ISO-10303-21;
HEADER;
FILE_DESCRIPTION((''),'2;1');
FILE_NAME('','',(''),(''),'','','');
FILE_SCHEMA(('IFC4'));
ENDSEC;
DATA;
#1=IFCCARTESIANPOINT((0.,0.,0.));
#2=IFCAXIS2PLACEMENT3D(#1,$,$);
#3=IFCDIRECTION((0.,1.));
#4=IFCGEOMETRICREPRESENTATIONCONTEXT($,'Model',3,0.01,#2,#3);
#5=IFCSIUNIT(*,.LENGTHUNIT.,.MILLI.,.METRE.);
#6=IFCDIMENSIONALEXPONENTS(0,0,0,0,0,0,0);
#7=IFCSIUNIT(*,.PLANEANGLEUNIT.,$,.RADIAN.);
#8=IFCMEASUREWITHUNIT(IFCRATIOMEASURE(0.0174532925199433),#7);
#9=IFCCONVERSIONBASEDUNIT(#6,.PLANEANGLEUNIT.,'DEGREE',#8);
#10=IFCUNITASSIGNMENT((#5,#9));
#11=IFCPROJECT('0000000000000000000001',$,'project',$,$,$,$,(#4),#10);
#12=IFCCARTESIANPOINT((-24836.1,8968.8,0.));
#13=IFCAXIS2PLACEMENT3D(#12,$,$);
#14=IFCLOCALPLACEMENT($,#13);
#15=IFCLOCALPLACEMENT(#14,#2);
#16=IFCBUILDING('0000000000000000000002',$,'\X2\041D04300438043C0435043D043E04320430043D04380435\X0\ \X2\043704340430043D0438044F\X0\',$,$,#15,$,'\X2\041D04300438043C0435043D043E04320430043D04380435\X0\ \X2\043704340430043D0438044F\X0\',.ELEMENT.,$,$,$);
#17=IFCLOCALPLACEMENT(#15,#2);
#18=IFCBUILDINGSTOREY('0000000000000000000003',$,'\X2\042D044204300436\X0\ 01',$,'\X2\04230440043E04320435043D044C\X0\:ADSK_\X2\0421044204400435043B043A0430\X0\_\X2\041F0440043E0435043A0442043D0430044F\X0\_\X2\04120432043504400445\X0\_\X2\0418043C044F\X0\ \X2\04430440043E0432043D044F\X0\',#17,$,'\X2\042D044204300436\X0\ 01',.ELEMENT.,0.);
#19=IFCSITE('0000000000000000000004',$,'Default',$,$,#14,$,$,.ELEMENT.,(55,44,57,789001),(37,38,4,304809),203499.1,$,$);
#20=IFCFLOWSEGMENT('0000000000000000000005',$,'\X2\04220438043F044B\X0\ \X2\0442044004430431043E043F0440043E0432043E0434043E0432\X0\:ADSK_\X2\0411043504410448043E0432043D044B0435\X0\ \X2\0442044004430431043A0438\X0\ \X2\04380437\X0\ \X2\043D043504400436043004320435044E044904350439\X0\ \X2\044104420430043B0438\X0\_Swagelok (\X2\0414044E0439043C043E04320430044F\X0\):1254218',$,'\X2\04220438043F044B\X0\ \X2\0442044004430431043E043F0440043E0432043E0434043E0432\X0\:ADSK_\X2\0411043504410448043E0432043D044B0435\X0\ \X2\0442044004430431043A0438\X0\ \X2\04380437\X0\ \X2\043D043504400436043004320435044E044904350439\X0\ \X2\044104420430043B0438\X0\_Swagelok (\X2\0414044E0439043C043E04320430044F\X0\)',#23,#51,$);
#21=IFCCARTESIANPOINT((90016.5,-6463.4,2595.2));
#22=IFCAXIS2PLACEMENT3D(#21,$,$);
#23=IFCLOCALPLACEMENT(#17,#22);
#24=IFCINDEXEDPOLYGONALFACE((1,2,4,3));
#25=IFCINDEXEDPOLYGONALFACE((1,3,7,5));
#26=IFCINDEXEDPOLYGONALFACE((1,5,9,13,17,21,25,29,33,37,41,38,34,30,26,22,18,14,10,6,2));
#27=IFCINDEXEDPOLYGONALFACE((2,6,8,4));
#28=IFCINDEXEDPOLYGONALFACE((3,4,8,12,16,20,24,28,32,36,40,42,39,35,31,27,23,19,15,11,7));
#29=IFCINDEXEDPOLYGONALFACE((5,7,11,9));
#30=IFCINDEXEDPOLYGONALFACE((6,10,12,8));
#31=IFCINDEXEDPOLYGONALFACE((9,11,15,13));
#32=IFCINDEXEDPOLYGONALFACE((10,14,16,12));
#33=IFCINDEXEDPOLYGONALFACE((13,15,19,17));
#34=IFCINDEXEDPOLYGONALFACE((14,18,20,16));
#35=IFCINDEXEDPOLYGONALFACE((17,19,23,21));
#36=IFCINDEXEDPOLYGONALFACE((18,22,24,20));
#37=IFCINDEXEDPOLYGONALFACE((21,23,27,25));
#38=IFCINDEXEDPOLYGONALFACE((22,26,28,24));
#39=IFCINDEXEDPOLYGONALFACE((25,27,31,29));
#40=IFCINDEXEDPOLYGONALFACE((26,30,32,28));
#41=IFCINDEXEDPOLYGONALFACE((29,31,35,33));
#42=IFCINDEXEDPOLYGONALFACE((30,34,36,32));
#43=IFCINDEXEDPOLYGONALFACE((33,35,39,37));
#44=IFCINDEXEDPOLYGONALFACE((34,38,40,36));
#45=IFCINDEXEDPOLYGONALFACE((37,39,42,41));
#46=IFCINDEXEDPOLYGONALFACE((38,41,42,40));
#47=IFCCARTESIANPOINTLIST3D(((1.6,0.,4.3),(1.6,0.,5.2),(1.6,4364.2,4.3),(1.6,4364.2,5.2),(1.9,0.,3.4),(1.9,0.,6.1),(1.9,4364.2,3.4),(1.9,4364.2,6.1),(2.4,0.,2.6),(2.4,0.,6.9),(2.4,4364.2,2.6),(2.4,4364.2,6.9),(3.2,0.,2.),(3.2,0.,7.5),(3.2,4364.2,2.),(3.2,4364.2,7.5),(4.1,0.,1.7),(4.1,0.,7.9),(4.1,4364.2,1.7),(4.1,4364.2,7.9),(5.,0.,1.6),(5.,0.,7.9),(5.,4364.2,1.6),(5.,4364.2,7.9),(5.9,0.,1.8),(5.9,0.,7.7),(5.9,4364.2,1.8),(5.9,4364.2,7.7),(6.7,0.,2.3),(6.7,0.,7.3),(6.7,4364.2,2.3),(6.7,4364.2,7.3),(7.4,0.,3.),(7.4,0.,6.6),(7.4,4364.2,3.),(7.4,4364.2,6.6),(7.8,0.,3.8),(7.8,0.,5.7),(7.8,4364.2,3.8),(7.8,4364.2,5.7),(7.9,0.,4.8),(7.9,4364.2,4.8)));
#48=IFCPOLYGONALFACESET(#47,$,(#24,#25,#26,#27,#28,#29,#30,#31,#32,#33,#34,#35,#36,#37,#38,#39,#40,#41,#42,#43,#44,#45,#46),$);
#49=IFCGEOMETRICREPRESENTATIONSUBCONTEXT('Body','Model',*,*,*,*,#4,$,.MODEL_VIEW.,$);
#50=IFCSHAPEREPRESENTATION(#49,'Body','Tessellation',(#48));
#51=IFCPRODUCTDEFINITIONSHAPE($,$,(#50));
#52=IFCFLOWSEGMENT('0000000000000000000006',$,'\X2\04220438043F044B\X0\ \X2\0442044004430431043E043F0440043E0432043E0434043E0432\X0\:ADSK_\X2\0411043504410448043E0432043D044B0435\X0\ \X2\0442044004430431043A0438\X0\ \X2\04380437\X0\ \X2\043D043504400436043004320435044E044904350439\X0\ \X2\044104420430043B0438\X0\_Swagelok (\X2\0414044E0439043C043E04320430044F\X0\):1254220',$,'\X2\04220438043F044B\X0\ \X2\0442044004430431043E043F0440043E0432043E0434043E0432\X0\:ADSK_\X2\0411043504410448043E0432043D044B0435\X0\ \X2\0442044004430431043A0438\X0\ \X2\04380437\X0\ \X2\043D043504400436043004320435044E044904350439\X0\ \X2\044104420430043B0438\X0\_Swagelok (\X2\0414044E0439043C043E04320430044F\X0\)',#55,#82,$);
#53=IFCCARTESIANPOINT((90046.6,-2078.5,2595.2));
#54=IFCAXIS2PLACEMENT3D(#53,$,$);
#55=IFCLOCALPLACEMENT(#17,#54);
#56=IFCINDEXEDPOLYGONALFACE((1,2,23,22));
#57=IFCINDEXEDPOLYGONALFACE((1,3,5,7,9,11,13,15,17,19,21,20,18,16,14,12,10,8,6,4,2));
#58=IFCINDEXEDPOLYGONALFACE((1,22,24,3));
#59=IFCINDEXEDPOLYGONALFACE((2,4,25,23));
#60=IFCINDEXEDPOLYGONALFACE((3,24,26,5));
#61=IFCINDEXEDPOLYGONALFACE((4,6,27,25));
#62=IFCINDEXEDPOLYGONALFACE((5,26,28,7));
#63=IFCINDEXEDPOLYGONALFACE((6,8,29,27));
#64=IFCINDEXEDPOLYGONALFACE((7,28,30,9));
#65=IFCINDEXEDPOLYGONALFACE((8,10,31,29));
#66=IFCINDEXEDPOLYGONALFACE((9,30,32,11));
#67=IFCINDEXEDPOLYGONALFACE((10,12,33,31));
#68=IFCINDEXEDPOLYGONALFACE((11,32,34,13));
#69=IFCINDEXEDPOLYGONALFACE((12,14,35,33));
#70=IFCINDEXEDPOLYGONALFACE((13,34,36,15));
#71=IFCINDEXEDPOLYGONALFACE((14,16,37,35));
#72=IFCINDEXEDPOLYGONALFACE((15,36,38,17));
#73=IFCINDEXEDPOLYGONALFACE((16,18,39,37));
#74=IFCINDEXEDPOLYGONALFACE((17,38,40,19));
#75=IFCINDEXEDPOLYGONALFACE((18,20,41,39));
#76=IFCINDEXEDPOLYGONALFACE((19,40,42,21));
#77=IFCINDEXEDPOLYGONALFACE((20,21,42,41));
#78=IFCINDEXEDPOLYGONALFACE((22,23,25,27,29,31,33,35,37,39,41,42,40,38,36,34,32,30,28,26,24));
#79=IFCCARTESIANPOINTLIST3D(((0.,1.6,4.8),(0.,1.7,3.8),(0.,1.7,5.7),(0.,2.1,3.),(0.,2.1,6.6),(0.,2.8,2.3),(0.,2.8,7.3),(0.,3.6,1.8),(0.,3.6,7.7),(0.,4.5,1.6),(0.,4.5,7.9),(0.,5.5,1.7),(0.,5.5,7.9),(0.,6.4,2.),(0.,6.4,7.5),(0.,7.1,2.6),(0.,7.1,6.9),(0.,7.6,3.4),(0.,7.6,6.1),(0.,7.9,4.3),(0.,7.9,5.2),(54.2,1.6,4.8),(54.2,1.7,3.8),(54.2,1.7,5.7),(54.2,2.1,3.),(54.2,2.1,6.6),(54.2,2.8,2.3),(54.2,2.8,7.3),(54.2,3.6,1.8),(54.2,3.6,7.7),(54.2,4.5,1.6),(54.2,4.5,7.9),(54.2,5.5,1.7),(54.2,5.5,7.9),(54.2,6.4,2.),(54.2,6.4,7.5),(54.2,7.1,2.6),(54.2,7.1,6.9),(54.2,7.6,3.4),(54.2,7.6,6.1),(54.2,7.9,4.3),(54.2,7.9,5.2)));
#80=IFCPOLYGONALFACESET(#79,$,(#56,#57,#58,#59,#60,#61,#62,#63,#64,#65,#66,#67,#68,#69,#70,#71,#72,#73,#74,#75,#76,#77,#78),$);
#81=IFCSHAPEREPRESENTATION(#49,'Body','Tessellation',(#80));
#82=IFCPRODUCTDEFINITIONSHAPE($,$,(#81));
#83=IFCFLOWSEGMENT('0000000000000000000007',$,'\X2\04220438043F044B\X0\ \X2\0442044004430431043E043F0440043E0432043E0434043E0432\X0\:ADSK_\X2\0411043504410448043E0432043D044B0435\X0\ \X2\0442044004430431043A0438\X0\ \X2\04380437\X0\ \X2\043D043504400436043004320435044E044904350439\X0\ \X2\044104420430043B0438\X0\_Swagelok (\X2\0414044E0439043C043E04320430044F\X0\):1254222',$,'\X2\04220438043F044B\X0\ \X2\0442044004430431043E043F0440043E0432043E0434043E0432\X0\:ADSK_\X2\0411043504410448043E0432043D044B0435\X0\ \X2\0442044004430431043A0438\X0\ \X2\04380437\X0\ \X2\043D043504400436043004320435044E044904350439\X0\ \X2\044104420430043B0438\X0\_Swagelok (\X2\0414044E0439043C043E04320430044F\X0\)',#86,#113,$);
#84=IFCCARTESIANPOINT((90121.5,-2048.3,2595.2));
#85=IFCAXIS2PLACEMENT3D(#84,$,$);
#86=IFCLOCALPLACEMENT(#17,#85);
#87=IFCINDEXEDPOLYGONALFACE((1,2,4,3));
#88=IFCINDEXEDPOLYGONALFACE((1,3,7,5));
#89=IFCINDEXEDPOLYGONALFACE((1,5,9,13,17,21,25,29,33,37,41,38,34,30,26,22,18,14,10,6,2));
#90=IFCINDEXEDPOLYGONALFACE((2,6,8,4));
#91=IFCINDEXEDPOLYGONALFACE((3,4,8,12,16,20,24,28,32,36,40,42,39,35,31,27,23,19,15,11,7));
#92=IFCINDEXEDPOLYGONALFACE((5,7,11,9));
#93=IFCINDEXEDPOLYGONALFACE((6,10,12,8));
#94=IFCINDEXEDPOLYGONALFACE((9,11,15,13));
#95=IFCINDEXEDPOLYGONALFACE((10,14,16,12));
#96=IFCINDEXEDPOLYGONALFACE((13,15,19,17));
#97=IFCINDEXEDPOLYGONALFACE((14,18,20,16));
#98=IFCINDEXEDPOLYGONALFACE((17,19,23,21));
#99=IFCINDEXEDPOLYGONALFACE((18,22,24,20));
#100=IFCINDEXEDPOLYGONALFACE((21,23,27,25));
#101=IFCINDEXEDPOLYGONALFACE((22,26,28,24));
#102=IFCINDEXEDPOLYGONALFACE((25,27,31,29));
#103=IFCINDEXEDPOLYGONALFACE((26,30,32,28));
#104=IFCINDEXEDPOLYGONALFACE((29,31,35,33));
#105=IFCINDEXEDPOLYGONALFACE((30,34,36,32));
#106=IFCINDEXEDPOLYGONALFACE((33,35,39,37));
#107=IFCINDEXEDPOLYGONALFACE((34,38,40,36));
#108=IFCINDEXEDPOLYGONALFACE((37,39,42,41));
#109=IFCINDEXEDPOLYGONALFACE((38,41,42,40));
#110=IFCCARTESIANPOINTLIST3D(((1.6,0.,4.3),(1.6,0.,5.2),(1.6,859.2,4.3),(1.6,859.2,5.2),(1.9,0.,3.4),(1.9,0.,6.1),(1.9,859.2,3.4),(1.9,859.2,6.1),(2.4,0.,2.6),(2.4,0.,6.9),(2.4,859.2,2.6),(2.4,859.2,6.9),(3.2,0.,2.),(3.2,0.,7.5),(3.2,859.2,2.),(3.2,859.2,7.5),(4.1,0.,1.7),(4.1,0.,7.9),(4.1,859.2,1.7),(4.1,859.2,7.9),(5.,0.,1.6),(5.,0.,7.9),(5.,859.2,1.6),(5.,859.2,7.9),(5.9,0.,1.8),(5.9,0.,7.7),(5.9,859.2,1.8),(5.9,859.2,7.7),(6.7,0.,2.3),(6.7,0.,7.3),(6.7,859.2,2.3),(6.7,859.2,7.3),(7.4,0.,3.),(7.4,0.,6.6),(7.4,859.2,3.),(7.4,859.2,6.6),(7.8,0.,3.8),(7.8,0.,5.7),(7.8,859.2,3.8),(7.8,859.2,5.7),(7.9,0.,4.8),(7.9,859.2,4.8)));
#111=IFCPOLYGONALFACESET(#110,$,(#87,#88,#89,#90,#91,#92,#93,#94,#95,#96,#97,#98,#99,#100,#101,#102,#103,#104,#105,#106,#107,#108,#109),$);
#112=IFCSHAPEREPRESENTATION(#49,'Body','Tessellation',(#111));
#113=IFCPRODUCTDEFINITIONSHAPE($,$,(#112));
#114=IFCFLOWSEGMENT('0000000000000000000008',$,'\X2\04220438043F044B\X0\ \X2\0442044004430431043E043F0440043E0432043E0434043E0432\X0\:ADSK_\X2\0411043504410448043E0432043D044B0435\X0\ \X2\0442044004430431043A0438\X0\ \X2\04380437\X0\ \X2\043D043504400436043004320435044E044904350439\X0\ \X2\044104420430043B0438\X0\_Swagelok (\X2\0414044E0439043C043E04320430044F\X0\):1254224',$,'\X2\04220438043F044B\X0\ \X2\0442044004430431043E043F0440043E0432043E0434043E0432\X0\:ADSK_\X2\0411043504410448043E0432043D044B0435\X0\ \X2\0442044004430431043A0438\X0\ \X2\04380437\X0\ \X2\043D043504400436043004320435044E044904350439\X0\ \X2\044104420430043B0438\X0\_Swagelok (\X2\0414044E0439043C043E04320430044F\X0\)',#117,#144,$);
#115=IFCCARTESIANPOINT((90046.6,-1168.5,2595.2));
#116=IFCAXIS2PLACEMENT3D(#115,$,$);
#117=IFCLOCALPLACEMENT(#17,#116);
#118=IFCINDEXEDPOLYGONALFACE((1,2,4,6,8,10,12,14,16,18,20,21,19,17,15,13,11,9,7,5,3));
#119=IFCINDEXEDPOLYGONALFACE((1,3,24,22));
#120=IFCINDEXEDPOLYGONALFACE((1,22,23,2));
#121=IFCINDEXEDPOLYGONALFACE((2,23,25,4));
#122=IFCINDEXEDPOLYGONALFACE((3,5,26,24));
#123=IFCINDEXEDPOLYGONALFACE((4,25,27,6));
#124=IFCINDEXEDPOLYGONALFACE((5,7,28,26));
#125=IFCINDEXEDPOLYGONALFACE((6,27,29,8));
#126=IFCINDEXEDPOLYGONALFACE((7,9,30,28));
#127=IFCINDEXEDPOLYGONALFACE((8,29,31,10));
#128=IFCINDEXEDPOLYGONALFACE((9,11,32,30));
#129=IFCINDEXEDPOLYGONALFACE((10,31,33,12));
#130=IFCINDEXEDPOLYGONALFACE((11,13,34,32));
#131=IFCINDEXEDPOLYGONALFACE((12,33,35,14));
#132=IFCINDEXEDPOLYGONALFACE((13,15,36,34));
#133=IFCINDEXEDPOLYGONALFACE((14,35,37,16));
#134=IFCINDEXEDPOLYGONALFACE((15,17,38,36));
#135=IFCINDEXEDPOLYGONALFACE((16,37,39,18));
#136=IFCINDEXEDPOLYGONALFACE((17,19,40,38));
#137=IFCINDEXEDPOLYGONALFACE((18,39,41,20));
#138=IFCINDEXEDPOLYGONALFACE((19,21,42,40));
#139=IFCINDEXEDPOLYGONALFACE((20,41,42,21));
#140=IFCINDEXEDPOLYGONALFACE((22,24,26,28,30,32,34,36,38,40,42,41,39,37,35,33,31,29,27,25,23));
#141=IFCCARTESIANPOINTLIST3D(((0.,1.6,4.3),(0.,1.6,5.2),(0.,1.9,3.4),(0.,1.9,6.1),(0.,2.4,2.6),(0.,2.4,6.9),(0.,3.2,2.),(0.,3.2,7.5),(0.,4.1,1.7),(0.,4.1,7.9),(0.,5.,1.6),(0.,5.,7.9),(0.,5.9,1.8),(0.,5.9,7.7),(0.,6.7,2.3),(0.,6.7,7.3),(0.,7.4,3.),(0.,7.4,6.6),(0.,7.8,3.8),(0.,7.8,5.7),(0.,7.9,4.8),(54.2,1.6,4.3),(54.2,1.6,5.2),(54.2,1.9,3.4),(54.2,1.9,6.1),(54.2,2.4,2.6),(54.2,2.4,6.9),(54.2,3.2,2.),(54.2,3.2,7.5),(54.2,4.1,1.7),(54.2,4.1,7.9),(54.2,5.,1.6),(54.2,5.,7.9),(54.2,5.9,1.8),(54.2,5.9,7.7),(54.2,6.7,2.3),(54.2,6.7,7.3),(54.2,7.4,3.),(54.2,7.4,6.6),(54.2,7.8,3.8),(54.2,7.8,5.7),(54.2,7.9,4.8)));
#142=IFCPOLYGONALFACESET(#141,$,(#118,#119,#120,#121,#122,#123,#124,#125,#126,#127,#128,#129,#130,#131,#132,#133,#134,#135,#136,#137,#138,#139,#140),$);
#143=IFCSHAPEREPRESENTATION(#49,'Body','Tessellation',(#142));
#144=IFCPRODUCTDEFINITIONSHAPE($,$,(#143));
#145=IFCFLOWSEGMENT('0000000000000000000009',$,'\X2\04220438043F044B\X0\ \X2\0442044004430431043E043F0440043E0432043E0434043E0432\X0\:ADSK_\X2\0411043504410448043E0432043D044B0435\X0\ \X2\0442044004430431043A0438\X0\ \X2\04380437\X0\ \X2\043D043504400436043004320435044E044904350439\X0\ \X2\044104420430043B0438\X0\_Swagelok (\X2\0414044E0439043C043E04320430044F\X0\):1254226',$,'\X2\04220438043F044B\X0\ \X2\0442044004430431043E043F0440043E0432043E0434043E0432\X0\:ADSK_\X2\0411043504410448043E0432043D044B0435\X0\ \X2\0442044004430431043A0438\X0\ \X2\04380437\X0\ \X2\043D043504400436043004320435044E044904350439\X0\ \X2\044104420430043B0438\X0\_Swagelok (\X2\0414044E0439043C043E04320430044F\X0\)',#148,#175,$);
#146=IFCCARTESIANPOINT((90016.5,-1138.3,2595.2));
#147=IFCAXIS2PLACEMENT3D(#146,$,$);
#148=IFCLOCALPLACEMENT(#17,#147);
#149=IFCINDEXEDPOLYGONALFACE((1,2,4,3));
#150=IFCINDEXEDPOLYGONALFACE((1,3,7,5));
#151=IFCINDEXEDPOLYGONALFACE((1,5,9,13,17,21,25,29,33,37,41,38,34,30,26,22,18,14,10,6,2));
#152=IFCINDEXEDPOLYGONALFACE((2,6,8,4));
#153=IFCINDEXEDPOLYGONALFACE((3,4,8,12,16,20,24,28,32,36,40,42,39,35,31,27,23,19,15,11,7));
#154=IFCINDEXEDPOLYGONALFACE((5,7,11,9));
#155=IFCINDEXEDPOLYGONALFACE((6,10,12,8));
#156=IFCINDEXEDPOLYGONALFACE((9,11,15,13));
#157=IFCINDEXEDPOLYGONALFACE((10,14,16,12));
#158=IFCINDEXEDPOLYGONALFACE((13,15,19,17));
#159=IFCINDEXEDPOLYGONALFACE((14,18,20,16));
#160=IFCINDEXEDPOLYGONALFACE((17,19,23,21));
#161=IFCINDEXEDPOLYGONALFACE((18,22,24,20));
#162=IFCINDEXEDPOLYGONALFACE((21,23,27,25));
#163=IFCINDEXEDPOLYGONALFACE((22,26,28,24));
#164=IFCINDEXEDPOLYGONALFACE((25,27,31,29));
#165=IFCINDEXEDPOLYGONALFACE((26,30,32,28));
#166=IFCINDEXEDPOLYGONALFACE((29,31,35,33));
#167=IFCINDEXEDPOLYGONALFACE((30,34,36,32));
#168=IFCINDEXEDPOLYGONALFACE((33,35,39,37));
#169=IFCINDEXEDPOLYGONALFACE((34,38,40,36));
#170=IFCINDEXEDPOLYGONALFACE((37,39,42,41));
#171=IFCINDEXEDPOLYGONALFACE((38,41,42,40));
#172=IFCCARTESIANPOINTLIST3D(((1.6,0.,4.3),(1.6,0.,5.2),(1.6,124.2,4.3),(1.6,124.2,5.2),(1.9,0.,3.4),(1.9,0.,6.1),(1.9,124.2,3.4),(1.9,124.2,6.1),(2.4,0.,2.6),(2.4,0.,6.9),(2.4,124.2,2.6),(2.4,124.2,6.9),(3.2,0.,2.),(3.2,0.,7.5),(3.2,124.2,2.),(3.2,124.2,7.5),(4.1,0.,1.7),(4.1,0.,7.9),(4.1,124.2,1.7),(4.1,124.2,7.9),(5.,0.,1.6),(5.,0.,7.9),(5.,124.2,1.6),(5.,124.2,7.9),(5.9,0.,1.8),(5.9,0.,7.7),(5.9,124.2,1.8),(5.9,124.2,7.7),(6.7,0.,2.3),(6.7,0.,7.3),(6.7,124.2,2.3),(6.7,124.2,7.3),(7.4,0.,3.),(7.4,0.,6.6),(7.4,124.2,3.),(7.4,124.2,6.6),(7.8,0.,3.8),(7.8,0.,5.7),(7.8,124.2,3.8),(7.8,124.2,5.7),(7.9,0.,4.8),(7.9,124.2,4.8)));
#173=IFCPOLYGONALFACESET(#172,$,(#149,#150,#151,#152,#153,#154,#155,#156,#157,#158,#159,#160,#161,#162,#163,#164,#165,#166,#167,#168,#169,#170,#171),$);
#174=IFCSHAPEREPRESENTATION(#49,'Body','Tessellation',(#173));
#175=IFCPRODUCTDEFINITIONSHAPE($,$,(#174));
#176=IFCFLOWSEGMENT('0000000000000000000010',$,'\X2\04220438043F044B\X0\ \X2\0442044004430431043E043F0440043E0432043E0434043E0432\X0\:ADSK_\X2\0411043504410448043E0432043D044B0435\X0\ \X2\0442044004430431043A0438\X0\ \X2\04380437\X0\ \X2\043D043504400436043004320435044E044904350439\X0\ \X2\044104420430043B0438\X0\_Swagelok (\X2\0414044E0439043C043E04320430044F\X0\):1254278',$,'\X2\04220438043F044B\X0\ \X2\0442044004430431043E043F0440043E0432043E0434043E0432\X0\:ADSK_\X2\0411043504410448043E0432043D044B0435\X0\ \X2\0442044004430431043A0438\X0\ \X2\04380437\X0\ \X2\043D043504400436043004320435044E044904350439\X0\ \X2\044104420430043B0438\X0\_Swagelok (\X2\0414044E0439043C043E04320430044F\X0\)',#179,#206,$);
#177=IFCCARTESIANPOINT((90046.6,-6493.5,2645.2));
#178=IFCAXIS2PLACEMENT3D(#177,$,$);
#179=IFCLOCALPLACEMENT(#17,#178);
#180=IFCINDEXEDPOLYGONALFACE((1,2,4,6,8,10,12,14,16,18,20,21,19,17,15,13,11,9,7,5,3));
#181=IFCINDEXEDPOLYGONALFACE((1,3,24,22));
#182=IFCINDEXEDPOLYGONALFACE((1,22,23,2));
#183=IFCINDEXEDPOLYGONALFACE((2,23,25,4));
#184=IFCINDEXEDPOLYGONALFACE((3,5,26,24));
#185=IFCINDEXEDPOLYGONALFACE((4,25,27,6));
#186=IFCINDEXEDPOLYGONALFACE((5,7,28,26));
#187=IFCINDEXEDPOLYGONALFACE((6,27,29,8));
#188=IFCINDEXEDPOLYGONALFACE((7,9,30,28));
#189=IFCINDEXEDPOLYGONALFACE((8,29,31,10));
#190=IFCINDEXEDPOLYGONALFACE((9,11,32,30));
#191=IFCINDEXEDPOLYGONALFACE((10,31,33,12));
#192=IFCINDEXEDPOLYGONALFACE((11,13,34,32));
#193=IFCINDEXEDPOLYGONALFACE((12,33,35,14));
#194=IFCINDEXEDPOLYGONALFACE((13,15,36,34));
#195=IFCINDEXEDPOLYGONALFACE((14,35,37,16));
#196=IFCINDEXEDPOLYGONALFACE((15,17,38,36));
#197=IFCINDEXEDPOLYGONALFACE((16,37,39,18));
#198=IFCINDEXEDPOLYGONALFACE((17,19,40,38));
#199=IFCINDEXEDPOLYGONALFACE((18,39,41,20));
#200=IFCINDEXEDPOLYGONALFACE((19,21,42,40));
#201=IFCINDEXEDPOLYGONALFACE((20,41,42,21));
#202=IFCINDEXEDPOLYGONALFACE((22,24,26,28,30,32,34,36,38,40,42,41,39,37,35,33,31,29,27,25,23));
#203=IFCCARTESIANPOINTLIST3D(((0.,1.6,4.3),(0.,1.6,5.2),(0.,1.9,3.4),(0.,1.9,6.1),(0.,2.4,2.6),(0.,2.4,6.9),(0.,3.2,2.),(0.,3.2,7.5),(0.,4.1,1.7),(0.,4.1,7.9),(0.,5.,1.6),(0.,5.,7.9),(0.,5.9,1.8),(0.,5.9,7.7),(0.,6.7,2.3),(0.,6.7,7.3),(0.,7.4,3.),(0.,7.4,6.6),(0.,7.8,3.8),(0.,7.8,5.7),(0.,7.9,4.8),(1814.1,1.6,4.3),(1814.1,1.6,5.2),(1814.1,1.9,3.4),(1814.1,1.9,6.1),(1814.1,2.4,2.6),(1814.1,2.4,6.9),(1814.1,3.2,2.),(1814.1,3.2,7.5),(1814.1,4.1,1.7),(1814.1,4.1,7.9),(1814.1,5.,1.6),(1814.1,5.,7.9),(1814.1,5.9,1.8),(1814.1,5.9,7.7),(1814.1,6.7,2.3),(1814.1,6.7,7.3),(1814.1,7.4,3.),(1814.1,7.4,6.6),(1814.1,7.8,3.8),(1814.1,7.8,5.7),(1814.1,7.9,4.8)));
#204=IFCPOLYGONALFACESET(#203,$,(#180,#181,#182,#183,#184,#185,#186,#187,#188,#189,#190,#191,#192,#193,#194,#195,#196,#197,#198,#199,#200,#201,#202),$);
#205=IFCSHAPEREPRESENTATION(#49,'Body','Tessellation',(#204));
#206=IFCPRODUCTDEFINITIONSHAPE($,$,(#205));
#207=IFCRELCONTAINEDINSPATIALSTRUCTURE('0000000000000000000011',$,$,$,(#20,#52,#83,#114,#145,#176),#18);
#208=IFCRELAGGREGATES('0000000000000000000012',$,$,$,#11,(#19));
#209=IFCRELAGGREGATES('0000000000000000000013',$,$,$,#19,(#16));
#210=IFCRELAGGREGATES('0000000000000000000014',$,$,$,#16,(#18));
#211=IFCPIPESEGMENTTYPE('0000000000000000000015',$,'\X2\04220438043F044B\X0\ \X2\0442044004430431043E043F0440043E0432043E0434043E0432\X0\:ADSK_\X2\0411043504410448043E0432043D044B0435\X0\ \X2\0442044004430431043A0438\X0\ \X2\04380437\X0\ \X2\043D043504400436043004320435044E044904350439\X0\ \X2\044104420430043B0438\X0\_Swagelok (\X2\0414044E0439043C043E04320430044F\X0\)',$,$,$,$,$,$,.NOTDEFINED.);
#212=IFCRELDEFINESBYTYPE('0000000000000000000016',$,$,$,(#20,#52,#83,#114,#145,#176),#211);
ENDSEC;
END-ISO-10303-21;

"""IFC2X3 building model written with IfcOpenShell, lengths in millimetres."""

from ifc_helpers import new_model, entity, si_unit, converted_unit, direction, frame, origin, origin_2d_with_axis, place, context, subcontext, project, spatial, circle, extrude, type_object, element, save


model = new_model("IFC2X3")

# Units and contexts
model_context = context("Model", 3, precision=0.01, world=origin(), true_north=direction((0.0, 1.0)))
body_context = subcontext(model_context, "Body", "Model", "MODEL_VIEW")
ifc_project = project(units=[si_unit("LENGTHUNIT", "METRE", prefix="MILLI"), converted_unit("PLANEANGLEUNIT", "DEGREE", entity("IfcRatioMeasure", 0.0174532925199433), si_unit("PLANEANGLEUNIT", "RADIAN"), dimensions=[0, 0, 0, 0, 0, 0, 0])], contexts=[model_context])

# Site, building, storey
site_placement = place(None, frame((-24836.1, 8968.8, 0.0)))
site = spatial("IfcSite", under=ifc_project, at=site_placement, Name="Default", CompositionType="ELEMENT", RefLatitude=(55, 44, 57, 789001), RefLongitude=(37, 38, 4, 304809), RefElevation=203499.1)
building_placement = place(site_placement, origin())
building = spatial("IfcBuilding", under=site, at=building_placement, Name="Наименование здания", LongName="Наименование здания", CompositionType="ELEMENT")
storey_placement = place(building_placement, origin())
storey = spatial("IfcBuildingStorey", under=building, at=storey_placement, Name="Этаж 01", ObjectType="Уровень:ADSK_Стрелка_Проектная_Вверх_Имя уровня", LongName="Этаж 01", CompositionType="ELEMENT", Elevation=0.0)

# Flow segments
pipe_segment_type_1 = type_object("IfcPipeSegmentType", Name="Типы трубопроводов:ADSK_Бесшовные трубки из нержавеющей стали_Swagelok (Дюймовая)", PredefinedType="NOTDEFINED")
flow_segment_1_placement = place(storey_placement, frame((90016.5, -6463.4, 2595.2)))
element("IfcFlowSegment", 1, at=flow_segment_1_placement, inside=storey, type_object=pipe_segment_type_1, Name="Типы трубопроводов:ADSK_Бесшовные трубки из нержавеющей стали_Swagelok (Дюймовая):1254218", ObjectType="Типы трубопроводов:ADSK_Бесшовные трубки из нержавеющей стали_Swagelok (Дюймовая)", context=body_context, shape_type="SweptSolid", body=[
    extrude(circle(Radius=3.2, at=origin_2d_with_axis()), frame((4.8, 0.0, 4.8), z_axis=(0.0, 1.0, 0.0), x_axis=(1.0, 0.0, 0.0)), (0.0, 0.0, 1.0), 4364.2),
])
flow_segment_2_placement = place(storey_placement, frame((90046.6, -2078.5, 2595.2)))
element("IfcFlowSegment", 2, at=flow_segment_2_placement, inside=storey, type_object=pipe_segment_type_1, Name="Типы трубопроводов:ADSK_Бесшовные трубки из нержавеющей стали_Swagelok (Дюймовая):1254220", ObjectType="Типы трубопроводов:ADSK_Бесшовные трубки из нержавеющей стали_Swagelok (Дюймовая)", context=body_context, shape_type="SweptSolid", body=[
    extrude(circle(Radius=3.2, at=origin_2d_with_axis()), frame((0.0, 4.8, 4.8), z_axis=(1.0, 0.0, 0.0), x_axis=(0.0, -1.0, 0.0)), (0.0, 0.0, 1.0), 54.2),
])
flow_segment_3_placement = place(storey_placement, frame((90121.5, -2048.3, 2595.2)))
element("IfcFlowSegment", 3, at=flow_segment_3_placement, inside=storey, type_object=pipe_segment_type_1, Name="Типы трубопроводов:ADSK_Бесшовные трубки из нержавеющей стали_Swagelok (Дюймовая):1254222", ObjectType="Типы трубопроводов:ADSK_Бесшовные трубки из нержавеющей стали_Swagelok (Дюймовая)", context=body_context, shape_type="SweptSolid", body=[
    extrude(circle(Radius=3.2, at=origin_2d_with_axis()), frame((4.8, 0.0, 4.8), z_axis=(0.0, 1.0, 0.0), x_axis=(1.0, 0.0, 0.0)), (0.0, 0.0, 1.0), 859.2),
])
flow_segment_4_placement = place(storey_placement, frame((90046.6, -1168.5, 2595.2)))
element("IfcFlowSegment", 4, at=flow_segment_4_placement, inside=storey, type_object=pipe_segment_type_1, Name="Типы трубопроводов:ADSK_Бесшовные трубки из нержавеющей стали_Swagelok (Дюймовая):1254224", ObjectType="Типы трубопроводов:ADSK_Бесшовные трубки из нержавеющей стали_Swagelok (Дюймовая)", context=body_context, shape_type="SweptSolid", body=[
    extrude(circle(Radius=3.2, at=origin_2d_with_axis()), frame((0.0, 4.8, 4.8), z_axis=(1.0, 0.0, 0.0), x_axis=(0.0, 1.0, 0.0)), (0.0, 0.0, 1.0), 54.2),
])
flow_segment_5_placement = place(storey_placement, frame((90016.5, -1138.3, 2595.2)))
element("IfcFlowSegment", 5, at=flow_segment_5_placement, inside=storey, type_object=pipe_segment_type_1, Name="Типы трубопроводов:ADSK_Бесшовные трубки из нержавеющей стали_Swagelok (Дюймовая):1254226", ObjectType="Типы трубопроводов:ADSK_Бесшовные трубки из нержавеющей стали_Swagelok (Дюймовая)", context=body_context, shape_type="SweptSolid", body=[
    extrude(circle(Radius=3.2, at=origin_2d_with_axis()), frame((4.8, 0.0, 4.8), z_axis=(0.0, 1.0, 0.0), x_axis=(1.0, 0.0, 0.0)), (0.0, 0.0, 1.0), 124.2),
])
flow_segment_6_placement = place(storey_placement, frame((90046.6, -6493.5, 2645.2)))
element("IfcFlowSegment", 6, at=flow_segment_6_placement, inside=storey, type_object=pipe_segment_type_1, Name="Типы трубопроводов:ADSK_Бесшовные трубки из нержавеющей стали_Swagelok (Дюймовая):1254278", ObjectType="Типы трубопроводов:ADSK_Бесшовные трубки из нержавеющей стали_Swagelok (Дюймовая)", context=body_context, shape_type="SweptSolid", body=[
    extrude(circle(Radius=3.2, at=origin_2d_with_axis()), frame((0.0, 4.8, 4.8), z_axis=(1.0, 0.0, 0.0), x_axis=(0.0, 1.0, 0.0)), (0.0, 0.0, 1.0), 1814.1),
])

save(model, "model.ifc")
